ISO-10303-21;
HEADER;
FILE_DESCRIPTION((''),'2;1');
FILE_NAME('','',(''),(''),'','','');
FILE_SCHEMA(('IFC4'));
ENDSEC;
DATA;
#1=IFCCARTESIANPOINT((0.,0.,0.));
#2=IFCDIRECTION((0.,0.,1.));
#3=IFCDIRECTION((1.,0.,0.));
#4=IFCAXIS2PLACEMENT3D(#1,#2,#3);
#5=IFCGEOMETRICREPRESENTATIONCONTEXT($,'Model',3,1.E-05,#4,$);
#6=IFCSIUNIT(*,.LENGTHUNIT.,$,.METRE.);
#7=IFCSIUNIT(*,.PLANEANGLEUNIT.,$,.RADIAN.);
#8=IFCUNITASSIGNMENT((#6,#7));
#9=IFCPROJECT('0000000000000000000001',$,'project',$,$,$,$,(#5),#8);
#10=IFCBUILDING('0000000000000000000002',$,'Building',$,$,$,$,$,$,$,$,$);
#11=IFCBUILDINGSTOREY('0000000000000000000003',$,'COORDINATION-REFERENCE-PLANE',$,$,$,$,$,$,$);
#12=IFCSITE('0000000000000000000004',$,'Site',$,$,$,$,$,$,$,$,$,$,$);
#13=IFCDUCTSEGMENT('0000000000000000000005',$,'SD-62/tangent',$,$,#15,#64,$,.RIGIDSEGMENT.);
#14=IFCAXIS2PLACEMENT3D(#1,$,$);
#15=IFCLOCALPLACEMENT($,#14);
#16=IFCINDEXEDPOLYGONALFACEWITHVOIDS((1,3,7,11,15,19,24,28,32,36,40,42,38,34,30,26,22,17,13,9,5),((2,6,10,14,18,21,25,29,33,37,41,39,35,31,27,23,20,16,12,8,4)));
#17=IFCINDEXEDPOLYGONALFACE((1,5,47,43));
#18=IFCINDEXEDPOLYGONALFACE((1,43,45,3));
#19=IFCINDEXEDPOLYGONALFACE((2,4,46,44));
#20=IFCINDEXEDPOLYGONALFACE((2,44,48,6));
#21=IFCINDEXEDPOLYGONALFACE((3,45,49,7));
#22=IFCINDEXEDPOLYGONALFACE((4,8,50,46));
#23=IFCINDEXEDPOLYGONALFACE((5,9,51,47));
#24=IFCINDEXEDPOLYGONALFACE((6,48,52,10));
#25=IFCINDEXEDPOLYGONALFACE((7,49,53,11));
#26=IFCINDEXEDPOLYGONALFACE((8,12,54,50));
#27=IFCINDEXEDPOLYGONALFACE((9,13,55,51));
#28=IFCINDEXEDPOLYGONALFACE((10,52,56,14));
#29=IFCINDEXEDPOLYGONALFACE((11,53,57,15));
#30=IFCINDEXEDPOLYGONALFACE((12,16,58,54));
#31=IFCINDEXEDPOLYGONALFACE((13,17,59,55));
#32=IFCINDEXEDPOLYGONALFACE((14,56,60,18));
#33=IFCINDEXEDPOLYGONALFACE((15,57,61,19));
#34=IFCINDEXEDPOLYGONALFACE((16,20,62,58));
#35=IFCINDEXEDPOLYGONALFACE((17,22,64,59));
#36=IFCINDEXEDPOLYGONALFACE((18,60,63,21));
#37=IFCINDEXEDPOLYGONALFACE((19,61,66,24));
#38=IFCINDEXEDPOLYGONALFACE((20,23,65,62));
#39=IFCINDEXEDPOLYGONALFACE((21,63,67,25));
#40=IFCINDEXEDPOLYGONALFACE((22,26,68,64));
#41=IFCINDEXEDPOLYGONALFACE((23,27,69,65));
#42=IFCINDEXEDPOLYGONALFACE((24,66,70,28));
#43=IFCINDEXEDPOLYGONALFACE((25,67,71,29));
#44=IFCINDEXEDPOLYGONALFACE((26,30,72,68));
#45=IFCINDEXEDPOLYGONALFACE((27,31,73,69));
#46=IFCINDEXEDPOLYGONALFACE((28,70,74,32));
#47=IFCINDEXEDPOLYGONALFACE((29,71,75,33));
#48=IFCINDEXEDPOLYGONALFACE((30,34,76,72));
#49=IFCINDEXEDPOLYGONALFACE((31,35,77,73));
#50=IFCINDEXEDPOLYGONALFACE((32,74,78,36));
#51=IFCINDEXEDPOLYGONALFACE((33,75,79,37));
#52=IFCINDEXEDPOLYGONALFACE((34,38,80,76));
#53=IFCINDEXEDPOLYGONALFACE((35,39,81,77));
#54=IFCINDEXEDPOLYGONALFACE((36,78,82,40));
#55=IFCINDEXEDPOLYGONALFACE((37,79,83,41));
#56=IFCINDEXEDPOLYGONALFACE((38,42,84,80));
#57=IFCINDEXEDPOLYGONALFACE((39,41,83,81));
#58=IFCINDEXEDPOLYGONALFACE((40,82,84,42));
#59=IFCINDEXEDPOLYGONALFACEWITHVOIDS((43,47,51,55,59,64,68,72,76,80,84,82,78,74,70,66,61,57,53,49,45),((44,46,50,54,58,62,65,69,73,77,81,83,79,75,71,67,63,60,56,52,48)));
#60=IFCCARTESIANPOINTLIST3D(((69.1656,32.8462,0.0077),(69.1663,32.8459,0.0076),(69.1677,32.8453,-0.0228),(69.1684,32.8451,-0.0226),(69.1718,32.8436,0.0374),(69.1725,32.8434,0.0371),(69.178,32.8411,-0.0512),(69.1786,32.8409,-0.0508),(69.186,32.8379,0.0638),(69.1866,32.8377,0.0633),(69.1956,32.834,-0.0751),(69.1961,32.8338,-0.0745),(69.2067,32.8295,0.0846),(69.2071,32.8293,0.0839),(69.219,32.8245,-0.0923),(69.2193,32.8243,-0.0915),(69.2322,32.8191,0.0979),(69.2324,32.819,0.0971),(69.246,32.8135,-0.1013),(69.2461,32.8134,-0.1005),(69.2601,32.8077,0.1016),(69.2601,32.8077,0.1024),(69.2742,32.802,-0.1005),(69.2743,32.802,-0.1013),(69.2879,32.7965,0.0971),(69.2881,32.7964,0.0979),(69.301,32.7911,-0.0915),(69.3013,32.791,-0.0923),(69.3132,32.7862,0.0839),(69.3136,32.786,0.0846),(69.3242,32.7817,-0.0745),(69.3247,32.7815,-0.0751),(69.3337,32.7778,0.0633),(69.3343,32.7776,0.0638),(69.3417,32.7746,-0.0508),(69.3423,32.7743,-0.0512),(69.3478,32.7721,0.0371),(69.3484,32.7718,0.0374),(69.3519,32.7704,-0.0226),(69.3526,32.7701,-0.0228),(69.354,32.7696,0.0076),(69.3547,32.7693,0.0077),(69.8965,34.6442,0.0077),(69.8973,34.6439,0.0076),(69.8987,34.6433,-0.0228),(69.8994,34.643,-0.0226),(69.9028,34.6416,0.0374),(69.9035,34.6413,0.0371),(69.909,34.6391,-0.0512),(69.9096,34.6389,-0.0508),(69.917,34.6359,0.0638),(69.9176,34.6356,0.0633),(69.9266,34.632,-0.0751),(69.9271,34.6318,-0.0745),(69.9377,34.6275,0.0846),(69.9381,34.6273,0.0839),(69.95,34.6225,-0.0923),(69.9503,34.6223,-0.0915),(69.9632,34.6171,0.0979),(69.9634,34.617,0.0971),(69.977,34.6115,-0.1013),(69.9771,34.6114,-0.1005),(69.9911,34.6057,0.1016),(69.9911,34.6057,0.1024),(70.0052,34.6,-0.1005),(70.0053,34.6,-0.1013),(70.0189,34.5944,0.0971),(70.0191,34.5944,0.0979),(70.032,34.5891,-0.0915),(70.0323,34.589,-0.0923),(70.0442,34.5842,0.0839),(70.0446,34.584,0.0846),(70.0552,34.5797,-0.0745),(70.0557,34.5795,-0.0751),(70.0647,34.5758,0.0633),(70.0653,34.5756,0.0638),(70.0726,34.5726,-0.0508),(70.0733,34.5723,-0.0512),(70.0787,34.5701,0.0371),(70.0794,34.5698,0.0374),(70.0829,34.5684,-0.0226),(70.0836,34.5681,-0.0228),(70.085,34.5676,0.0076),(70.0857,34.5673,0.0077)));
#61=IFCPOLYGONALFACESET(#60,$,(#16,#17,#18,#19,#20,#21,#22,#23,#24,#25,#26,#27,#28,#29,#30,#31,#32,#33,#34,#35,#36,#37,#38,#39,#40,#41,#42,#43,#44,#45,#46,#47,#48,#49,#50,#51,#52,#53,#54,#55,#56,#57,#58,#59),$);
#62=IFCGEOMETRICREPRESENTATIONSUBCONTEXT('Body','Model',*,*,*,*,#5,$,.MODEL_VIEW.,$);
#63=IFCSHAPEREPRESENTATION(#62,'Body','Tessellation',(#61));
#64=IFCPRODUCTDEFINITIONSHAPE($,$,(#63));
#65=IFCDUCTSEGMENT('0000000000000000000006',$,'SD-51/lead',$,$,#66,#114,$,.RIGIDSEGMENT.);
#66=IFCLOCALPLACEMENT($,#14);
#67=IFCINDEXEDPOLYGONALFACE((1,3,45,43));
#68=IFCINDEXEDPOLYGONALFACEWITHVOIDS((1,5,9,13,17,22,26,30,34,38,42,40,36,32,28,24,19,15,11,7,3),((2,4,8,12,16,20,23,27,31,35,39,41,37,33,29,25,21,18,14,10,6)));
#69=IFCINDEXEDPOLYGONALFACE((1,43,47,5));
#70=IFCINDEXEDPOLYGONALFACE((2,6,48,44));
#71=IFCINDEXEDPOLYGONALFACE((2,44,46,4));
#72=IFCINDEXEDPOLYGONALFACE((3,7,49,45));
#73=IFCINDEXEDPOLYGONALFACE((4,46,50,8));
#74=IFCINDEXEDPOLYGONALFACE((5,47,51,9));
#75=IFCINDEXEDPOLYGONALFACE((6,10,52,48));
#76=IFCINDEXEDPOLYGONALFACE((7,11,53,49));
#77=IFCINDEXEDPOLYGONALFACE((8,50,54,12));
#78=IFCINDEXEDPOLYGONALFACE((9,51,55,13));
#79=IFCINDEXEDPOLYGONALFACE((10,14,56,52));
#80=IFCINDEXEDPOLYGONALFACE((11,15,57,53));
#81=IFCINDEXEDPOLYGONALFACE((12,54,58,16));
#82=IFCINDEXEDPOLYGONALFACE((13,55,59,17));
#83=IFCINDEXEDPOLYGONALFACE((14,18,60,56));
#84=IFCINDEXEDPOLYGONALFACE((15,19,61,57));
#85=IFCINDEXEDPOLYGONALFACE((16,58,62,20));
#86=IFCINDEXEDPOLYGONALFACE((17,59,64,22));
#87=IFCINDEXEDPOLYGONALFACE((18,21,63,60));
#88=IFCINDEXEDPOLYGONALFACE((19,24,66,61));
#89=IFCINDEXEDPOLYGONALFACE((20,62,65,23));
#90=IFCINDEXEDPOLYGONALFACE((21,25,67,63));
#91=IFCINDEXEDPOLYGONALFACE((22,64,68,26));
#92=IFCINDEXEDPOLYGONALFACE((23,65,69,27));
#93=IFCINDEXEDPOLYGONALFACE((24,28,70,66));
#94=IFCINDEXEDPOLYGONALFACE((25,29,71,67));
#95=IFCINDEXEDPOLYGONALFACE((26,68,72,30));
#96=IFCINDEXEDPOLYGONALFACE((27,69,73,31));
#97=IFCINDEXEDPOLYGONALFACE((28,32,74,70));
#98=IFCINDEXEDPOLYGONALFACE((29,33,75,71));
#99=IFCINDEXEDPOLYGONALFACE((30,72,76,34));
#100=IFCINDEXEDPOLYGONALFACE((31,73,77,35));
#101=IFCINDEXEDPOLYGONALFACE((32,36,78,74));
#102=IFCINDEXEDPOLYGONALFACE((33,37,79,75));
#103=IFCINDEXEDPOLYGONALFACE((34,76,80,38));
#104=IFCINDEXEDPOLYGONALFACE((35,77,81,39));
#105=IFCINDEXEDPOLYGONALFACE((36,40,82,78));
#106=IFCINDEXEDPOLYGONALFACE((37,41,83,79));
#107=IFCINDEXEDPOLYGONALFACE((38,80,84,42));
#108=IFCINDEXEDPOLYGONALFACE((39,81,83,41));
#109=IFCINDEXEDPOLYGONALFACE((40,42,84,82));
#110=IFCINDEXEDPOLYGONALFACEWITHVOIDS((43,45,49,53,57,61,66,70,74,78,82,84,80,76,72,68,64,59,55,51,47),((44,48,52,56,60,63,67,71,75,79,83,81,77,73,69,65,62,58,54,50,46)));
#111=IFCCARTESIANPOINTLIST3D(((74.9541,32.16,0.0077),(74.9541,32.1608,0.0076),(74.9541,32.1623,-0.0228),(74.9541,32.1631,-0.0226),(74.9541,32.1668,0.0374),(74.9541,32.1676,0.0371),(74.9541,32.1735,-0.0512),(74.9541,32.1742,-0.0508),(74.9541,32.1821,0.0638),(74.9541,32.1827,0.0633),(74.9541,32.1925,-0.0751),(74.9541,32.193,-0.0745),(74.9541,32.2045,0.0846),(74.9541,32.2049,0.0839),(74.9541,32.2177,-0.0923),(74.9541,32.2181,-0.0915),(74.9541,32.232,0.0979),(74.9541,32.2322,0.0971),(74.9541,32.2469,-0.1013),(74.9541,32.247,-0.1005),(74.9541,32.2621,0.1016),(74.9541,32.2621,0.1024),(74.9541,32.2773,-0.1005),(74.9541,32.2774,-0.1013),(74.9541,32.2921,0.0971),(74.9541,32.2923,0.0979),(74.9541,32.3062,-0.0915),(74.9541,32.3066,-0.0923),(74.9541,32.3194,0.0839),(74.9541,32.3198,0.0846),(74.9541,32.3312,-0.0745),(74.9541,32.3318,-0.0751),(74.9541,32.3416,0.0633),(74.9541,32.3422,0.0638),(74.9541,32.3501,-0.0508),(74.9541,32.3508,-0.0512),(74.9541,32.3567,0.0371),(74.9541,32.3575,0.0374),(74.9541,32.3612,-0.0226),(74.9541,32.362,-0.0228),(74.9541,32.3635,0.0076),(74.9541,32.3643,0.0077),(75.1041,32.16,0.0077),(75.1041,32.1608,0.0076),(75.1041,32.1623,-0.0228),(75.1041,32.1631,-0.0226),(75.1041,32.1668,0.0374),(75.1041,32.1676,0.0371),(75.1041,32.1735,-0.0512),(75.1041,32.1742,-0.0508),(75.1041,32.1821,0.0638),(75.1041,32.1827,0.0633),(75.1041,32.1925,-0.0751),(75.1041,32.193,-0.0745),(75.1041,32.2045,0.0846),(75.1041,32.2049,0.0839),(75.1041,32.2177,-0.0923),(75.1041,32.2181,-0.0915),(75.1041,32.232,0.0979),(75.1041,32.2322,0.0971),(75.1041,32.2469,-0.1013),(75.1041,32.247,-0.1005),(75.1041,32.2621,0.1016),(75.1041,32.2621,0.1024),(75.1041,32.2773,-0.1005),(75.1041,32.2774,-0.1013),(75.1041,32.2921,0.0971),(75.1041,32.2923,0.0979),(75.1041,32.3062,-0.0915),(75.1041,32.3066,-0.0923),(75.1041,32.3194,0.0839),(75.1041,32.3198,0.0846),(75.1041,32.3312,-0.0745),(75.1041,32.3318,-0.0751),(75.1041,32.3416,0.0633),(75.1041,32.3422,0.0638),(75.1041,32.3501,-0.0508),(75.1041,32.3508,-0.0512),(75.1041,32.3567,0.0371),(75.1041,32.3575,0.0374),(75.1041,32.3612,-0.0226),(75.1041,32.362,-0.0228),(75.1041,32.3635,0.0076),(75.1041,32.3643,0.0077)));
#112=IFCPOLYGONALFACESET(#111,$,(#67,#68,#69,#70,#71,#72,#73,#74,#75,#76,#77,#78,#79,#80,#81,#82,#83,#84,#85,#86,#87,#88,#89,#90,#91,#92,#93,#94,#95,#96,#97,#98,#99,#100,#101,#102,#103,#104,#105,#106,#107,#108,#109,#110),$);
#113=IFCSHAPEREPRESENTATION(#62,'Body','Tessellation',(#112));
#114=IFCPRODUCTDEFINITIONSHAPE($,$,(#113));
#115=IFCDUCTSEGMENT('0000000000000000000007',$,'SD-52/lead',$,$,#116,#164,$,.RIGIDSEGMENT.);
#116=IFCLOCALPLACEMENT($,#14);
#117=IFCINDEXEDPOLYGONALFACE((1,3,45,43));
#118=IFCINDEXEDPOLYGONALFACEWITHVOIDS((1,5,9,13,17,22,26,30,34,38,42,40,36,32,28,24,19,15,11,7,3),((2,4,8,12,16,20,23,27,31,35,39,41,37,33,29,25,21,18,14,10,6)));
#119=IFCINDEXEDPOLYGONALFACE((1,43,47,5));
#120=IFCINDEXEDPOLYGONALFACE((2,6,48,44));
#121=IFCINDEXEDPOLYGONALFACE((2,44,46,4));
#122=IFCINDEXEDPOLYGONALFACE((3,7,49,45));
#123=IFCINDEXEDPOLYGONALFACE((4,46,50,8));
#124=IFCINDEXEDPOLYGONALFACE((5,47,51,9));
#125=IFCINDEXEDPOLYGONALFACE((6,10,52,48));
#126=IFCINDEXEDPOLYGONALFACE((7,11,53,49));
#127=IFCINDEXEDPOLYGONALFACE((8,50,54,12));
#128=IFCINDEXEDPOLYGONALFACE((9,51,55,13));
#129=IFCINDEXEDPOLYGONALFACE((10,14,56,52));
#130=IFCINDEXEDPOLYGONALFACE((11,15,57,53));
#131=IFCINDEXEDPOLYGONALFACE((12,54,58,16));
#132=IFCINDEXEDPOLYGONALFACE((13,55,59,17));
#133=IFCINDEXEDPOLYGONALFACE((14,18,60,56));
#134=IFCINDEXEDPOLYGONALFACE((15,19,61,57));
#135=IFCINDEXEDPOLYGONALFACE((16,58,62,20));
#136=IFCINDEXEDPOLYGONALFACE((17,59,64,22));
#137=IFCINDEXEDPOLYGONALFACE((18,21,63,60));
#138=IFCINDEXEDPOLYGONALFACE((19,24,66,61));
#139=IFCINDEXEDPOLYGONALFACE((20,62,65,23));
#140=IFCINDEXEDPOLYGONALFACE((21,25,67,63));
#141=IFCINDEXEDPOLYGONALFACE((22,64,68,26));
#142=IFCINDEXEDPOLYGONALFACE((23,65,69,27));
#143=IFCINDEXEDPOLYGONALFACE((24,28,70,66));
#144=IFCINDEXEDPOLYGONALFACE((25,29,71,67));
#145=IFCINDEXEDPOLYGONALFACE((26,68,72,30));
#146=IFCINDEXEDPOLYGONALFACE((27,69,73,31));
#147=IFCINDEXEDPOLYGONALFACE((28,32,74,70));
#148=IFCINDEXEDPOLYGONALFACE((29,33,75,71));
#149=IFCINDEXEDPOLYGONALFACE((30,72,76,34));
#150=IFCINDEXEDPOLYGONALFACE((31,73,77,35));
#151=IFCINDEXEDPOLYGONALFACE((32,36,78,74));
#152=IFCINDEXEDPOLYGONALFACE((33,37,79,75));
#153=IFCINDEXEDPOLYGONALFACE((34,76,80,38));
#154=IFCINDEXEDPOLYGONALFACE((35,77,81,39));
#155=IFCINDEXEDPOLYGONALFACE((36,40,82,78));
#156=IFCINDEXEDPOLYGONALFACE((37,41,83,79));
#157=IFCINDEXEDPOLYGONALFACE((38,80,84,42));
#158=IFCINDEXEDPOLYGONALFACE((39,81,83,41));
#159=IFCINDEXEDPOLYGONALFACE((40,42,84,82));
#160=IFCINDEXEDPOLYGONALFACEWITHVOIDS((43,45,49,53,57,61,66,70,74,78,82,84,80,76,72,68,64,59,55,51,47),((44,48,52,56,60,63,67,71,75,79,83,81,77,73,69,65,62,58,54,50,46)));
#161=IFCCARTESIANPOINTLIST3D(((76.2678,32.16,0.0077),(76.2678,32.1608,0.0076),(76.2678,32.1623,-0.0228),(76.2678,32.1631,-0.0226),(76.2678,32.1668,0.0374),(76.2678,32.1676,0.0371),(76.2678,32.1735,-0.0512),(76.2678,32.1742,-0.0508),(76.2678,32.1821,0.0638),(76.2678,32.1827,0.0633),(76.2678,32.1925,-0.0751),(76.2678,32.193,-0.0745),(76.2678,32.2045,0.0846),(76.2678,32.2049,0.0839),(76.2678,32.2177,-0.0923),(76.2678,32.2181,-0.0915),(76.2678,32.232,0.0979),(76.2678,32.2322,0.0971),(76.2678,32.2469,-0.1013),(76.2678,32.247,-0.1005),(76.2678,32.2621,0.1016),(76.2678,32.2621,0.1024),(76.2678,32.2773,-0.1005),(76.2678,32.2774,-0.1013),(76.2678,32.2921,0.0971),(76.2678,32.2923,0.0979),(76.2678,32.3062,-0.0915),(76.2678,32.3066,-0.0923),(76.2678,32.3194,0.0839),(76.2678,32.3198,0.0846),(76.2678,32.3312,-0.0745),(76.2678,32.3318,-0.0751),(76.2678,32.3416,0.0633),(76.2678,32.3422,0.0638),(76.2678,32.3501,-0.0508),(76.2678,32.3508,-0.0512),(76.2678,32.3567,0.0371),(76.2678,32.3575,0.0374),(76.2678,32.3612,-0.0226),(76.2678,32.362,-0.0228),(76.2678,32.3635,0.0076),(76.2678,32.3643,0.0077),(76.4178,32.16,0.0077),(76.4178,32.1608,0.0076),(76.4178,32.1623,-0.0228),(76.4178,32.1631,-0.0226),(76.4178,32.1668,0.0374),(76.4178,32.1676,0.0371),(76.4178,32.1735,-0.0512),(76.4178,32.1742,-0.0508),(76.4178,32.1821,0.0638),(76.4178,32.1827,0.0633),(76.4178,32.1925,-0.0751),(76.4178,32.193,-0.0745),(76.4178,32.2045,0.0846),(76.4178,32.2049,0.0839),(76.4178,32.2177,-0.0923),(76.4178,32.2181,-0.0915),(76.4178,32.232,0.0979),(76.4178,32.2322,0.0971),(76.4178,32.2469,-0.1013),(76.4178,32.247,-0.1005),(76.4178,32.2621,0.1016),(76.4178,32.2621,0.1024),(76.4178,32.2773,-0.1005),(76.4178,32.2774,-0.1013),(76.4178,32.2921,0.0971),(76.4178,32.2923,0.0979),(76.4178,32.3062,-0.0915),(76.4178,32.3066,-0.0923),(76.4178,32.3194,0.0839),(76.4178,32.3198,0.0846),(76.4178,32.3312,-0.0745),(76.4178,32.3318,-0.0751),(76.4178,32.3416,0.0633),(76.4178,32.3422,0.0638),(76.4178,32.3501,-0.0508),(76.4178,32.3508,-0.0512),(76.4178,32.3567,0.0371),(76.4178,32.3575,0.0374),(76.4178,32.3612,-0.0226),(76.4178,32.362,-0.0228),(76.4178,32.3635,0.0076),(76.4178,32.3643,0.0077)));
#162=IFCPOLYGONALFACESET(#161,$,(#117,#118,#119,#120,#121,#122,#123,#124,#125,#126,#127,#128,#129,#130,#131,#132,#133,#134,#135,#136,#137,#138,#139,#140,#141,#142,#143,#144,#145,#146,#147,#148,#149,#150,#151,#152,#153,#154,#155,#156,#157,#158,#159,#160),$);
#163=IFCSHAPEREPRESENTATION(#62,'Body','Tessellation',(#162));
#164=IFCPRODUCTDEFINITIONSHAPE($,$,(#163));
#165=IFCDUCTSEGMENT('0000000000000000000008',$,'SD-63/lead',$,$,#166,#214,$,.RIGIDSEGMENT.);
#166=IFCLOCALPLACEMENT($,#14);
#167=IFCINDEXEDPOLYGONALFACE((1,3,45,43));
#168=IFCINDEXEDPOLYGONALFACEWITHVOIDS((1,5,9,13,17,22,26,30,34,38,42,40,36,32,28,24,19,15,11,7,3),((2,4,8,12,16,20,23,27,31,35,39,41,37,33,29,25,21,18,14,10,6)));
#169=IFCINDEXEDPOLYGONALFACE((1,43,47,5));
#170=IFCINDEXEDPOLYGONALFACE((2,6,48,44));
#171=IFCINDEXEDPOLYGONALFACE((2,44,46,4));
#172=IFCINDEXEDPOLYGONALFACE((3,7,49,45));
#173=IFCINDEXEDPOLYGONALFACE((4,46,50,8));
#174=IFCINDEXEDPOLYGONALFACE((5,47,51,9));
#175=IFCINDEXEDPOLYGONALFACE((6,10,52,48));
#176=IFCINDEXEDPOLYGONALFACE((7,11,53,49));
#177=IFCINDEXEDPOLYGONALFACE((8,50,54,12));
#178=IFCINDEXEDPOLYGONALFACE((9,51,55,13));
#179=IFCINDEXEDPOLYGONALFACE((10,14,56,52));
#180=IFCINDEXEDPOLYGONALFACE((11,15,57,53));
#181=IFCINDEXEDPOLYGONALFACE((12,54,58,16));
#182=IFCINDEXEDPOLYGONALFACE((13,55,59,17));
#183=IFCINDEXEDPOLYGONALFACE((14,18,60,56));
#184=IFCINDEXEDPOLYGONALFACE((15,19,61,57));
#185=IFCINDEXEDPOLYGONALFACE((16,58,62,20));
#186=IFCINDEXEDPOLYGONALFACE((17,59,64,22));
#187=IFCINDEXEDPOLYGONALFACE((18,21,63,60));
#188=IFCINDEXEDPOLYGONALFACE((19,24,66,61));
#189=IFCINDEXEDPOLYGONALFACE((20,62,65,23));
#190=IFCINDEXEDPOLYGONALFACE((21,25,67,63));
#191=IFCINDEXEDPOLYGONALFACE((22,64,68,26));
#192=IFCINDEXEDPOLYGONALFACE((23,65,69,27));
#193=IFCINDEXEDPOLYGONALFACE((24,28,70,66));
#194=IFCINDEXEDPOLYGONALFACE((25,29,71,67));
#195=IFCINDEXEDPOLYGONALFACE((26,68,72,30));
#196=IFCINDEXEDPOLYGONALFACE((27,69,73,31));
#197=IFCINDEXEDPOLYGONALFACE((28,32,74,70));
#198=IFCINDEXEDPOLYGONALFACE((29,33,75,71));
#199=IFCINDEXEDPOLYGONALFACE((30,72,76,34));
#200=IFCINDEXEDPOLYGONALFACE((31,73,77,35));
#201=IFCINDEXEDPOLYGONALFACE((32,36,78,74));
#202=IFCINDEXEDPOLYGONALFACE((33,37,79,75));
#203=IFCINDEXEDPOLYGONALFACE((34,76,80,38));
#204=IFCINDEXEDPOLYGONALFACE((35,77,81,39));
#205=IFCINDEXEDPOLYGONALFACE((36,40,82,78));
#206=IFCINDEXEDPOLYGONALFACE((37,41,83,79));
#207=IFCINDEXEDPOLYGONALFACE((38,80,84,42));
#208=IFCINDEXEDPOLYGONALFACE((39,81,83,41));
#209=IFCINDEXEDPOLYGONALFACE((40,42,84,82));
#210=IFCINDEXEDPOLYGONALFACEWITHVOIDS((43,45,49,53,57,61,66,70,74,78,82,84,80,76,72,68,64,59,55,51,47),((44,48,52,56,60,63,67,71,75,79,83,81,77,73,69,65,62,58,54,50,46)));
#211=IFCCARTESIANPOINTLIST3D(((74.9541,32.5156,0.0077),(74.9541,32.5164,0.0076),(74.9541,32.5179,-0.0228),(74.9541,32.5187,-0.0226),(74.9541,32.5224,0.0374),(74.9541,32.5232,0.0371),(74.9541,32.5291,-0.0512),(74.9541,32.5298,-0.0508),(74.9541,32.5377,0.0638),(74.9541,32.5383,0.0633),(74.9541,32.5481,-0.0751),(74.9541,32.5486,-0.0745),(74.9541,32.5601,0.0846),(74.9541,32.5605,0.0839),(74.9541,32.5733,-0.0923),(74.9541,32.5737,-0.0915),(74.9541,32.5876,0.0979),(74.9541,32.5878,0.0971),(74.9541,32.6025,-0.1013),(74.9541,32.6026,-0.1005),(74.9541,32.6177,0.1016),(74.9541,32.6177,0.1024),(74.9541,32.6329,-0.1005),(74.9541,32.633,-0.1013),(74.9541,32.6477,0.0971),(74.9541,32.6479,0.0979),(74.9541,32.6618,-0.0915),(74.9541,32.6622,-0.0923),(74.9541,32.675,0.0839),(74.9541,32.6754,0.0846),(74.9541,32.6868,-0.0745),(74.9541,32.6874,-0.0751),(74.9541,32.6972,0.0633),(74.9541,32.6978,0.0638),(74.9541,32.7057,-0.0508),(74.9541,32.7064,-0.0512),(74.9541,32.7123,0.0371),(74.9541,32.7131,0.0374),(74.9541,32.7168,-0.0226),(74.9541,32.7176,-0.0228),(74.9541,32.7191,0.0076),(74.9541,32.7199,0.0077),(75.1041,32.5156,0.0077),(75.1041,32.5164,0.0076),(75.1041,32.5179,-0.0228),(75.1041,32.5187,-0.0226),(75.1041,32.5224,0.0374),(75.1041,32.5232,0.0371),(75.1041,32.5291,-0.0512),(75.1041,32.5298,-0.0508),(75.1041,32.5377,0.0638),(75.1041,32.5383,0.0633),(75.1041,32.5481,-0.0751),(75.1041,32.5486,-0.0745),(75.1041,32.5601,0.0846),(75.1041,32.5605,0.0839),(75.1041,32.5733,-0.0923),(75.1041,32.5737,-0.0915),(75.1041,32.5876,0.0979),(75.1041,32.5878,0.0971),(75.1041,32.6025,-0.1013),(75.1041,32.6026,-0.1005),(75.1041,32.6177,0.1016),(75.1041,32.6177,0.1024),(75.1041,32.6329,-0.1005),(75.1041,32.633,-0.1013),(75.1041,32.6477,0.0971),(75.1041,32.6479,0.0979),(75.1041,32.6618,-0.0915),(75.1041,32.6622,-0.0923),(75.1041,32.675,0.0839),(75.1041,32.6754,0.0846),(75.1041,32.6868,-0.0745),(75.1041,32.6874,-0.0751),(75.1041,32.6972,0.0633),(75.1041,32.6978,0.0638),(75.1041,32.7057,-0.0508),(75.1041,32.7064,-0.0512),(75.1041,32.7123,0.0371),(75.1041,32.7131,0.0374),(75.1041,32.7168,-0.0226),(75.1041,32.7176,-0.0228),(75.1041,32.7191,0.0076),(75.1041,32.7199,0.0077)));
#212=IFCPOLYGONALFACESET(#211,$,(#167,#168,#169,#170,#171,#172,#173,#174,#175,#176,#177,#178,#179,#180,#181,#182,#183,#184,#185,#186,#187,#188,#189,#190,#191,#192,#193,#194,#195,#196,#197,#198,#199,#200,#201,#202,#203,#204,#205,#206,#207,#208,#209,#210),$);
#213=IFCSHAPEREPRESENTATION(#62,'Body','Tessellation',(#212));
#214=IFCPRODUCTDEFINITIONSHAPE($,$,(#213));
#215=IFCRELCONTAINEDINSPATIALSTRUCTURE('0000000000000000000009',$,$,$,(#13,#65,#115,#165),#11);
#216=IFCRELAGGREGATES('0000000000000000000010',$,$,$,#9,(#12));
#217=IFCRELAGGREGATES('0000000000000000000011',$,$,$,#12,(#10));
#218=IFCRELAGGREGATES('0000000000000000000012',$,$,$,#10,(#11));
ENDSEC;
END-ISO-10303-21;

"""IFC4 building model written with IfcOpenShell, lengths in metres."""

from ifc_helpers import new_model, si_unit, frame, origin_with_axes, place, context, subcontext, project, spatial, hollow_circle, extrude, element, save


model = new_model("IFC4")

# Units and contexts
model_context = context("Model", 3, precision=1e-05, world=origin_with_axes())
body_context_1 = subcontext(model_context, "Body", "Model", "MODEL_VIEW")
ifc_project = project(units=[si_unit("LENGTHUNIT", "METRE"), si_unit("PLANEANGLEUNIT", "RADIAN")], contexts=[model_context])

# Site, building, storey
site = spatial("IfcSite", under=ifc_project, Name="Site")
building = spatial("IfcBuilding", under=site, Name="Building")
storey = spatial("IfcBuildingStorey", under=building, Name="COORDINATION-REFERENCE-PLANE")

# Duct segment
duct_segment_1_placement = place(None, frame((69.2601, 32.8077, 0.0), z_axis=(0.376625, 0.926366, 0.0), x_axis=(0.0, 0.0, 1.0)))
element("IfcDuctSegment", 1, at=duct_segment_1_placement, inside=storey, Name="SD-62/tangent", PredefinedType="RIGIDSEGMENT", context=body_context_1, shape_type="SweptSolid", body=[
    extrude(hollow_circle(Radius=0.1024, WallThickness=0.0008), origin_with_axes(), (0.0, 0.0, 1.0), 1.9409),
])

# Duct segments
for number, where, z_axis, x_axis, name in (
    (2, (75.1041, 32.2621, 0.0), (-1.0, 0.0, 0.0), (0.0, 0.0, 1.0), "SD-51/lead"),
    (3, (76.2678, 32.2621, 0.0), (1.0, 0.0, 0.0), (0.0, 0.0, 1.0), "SD-52/lead"),
    (4, (75.1041, 32.6177, 0.0), (-1.0, 0.0, 0.0), (0.0, 0.0, 1.0), "SD-63/lead"),
):
    element("IfcDuctSegment", number, at=place(None, frame(where, z_axis=z_axis, x_axis=x_axis)), inside=storey, Name=name, PredefinedType="RIGIDSEGMENT", context=body_context_1, shape_type="SweptSolid", body=[
        extrude(hollow_circle(Radius=0.1024, WallThickness=0.0008), origin_with_axes(), (0.0, 0.0, 1.0), 0.15),
    ])

save(model, "model.ifc")
